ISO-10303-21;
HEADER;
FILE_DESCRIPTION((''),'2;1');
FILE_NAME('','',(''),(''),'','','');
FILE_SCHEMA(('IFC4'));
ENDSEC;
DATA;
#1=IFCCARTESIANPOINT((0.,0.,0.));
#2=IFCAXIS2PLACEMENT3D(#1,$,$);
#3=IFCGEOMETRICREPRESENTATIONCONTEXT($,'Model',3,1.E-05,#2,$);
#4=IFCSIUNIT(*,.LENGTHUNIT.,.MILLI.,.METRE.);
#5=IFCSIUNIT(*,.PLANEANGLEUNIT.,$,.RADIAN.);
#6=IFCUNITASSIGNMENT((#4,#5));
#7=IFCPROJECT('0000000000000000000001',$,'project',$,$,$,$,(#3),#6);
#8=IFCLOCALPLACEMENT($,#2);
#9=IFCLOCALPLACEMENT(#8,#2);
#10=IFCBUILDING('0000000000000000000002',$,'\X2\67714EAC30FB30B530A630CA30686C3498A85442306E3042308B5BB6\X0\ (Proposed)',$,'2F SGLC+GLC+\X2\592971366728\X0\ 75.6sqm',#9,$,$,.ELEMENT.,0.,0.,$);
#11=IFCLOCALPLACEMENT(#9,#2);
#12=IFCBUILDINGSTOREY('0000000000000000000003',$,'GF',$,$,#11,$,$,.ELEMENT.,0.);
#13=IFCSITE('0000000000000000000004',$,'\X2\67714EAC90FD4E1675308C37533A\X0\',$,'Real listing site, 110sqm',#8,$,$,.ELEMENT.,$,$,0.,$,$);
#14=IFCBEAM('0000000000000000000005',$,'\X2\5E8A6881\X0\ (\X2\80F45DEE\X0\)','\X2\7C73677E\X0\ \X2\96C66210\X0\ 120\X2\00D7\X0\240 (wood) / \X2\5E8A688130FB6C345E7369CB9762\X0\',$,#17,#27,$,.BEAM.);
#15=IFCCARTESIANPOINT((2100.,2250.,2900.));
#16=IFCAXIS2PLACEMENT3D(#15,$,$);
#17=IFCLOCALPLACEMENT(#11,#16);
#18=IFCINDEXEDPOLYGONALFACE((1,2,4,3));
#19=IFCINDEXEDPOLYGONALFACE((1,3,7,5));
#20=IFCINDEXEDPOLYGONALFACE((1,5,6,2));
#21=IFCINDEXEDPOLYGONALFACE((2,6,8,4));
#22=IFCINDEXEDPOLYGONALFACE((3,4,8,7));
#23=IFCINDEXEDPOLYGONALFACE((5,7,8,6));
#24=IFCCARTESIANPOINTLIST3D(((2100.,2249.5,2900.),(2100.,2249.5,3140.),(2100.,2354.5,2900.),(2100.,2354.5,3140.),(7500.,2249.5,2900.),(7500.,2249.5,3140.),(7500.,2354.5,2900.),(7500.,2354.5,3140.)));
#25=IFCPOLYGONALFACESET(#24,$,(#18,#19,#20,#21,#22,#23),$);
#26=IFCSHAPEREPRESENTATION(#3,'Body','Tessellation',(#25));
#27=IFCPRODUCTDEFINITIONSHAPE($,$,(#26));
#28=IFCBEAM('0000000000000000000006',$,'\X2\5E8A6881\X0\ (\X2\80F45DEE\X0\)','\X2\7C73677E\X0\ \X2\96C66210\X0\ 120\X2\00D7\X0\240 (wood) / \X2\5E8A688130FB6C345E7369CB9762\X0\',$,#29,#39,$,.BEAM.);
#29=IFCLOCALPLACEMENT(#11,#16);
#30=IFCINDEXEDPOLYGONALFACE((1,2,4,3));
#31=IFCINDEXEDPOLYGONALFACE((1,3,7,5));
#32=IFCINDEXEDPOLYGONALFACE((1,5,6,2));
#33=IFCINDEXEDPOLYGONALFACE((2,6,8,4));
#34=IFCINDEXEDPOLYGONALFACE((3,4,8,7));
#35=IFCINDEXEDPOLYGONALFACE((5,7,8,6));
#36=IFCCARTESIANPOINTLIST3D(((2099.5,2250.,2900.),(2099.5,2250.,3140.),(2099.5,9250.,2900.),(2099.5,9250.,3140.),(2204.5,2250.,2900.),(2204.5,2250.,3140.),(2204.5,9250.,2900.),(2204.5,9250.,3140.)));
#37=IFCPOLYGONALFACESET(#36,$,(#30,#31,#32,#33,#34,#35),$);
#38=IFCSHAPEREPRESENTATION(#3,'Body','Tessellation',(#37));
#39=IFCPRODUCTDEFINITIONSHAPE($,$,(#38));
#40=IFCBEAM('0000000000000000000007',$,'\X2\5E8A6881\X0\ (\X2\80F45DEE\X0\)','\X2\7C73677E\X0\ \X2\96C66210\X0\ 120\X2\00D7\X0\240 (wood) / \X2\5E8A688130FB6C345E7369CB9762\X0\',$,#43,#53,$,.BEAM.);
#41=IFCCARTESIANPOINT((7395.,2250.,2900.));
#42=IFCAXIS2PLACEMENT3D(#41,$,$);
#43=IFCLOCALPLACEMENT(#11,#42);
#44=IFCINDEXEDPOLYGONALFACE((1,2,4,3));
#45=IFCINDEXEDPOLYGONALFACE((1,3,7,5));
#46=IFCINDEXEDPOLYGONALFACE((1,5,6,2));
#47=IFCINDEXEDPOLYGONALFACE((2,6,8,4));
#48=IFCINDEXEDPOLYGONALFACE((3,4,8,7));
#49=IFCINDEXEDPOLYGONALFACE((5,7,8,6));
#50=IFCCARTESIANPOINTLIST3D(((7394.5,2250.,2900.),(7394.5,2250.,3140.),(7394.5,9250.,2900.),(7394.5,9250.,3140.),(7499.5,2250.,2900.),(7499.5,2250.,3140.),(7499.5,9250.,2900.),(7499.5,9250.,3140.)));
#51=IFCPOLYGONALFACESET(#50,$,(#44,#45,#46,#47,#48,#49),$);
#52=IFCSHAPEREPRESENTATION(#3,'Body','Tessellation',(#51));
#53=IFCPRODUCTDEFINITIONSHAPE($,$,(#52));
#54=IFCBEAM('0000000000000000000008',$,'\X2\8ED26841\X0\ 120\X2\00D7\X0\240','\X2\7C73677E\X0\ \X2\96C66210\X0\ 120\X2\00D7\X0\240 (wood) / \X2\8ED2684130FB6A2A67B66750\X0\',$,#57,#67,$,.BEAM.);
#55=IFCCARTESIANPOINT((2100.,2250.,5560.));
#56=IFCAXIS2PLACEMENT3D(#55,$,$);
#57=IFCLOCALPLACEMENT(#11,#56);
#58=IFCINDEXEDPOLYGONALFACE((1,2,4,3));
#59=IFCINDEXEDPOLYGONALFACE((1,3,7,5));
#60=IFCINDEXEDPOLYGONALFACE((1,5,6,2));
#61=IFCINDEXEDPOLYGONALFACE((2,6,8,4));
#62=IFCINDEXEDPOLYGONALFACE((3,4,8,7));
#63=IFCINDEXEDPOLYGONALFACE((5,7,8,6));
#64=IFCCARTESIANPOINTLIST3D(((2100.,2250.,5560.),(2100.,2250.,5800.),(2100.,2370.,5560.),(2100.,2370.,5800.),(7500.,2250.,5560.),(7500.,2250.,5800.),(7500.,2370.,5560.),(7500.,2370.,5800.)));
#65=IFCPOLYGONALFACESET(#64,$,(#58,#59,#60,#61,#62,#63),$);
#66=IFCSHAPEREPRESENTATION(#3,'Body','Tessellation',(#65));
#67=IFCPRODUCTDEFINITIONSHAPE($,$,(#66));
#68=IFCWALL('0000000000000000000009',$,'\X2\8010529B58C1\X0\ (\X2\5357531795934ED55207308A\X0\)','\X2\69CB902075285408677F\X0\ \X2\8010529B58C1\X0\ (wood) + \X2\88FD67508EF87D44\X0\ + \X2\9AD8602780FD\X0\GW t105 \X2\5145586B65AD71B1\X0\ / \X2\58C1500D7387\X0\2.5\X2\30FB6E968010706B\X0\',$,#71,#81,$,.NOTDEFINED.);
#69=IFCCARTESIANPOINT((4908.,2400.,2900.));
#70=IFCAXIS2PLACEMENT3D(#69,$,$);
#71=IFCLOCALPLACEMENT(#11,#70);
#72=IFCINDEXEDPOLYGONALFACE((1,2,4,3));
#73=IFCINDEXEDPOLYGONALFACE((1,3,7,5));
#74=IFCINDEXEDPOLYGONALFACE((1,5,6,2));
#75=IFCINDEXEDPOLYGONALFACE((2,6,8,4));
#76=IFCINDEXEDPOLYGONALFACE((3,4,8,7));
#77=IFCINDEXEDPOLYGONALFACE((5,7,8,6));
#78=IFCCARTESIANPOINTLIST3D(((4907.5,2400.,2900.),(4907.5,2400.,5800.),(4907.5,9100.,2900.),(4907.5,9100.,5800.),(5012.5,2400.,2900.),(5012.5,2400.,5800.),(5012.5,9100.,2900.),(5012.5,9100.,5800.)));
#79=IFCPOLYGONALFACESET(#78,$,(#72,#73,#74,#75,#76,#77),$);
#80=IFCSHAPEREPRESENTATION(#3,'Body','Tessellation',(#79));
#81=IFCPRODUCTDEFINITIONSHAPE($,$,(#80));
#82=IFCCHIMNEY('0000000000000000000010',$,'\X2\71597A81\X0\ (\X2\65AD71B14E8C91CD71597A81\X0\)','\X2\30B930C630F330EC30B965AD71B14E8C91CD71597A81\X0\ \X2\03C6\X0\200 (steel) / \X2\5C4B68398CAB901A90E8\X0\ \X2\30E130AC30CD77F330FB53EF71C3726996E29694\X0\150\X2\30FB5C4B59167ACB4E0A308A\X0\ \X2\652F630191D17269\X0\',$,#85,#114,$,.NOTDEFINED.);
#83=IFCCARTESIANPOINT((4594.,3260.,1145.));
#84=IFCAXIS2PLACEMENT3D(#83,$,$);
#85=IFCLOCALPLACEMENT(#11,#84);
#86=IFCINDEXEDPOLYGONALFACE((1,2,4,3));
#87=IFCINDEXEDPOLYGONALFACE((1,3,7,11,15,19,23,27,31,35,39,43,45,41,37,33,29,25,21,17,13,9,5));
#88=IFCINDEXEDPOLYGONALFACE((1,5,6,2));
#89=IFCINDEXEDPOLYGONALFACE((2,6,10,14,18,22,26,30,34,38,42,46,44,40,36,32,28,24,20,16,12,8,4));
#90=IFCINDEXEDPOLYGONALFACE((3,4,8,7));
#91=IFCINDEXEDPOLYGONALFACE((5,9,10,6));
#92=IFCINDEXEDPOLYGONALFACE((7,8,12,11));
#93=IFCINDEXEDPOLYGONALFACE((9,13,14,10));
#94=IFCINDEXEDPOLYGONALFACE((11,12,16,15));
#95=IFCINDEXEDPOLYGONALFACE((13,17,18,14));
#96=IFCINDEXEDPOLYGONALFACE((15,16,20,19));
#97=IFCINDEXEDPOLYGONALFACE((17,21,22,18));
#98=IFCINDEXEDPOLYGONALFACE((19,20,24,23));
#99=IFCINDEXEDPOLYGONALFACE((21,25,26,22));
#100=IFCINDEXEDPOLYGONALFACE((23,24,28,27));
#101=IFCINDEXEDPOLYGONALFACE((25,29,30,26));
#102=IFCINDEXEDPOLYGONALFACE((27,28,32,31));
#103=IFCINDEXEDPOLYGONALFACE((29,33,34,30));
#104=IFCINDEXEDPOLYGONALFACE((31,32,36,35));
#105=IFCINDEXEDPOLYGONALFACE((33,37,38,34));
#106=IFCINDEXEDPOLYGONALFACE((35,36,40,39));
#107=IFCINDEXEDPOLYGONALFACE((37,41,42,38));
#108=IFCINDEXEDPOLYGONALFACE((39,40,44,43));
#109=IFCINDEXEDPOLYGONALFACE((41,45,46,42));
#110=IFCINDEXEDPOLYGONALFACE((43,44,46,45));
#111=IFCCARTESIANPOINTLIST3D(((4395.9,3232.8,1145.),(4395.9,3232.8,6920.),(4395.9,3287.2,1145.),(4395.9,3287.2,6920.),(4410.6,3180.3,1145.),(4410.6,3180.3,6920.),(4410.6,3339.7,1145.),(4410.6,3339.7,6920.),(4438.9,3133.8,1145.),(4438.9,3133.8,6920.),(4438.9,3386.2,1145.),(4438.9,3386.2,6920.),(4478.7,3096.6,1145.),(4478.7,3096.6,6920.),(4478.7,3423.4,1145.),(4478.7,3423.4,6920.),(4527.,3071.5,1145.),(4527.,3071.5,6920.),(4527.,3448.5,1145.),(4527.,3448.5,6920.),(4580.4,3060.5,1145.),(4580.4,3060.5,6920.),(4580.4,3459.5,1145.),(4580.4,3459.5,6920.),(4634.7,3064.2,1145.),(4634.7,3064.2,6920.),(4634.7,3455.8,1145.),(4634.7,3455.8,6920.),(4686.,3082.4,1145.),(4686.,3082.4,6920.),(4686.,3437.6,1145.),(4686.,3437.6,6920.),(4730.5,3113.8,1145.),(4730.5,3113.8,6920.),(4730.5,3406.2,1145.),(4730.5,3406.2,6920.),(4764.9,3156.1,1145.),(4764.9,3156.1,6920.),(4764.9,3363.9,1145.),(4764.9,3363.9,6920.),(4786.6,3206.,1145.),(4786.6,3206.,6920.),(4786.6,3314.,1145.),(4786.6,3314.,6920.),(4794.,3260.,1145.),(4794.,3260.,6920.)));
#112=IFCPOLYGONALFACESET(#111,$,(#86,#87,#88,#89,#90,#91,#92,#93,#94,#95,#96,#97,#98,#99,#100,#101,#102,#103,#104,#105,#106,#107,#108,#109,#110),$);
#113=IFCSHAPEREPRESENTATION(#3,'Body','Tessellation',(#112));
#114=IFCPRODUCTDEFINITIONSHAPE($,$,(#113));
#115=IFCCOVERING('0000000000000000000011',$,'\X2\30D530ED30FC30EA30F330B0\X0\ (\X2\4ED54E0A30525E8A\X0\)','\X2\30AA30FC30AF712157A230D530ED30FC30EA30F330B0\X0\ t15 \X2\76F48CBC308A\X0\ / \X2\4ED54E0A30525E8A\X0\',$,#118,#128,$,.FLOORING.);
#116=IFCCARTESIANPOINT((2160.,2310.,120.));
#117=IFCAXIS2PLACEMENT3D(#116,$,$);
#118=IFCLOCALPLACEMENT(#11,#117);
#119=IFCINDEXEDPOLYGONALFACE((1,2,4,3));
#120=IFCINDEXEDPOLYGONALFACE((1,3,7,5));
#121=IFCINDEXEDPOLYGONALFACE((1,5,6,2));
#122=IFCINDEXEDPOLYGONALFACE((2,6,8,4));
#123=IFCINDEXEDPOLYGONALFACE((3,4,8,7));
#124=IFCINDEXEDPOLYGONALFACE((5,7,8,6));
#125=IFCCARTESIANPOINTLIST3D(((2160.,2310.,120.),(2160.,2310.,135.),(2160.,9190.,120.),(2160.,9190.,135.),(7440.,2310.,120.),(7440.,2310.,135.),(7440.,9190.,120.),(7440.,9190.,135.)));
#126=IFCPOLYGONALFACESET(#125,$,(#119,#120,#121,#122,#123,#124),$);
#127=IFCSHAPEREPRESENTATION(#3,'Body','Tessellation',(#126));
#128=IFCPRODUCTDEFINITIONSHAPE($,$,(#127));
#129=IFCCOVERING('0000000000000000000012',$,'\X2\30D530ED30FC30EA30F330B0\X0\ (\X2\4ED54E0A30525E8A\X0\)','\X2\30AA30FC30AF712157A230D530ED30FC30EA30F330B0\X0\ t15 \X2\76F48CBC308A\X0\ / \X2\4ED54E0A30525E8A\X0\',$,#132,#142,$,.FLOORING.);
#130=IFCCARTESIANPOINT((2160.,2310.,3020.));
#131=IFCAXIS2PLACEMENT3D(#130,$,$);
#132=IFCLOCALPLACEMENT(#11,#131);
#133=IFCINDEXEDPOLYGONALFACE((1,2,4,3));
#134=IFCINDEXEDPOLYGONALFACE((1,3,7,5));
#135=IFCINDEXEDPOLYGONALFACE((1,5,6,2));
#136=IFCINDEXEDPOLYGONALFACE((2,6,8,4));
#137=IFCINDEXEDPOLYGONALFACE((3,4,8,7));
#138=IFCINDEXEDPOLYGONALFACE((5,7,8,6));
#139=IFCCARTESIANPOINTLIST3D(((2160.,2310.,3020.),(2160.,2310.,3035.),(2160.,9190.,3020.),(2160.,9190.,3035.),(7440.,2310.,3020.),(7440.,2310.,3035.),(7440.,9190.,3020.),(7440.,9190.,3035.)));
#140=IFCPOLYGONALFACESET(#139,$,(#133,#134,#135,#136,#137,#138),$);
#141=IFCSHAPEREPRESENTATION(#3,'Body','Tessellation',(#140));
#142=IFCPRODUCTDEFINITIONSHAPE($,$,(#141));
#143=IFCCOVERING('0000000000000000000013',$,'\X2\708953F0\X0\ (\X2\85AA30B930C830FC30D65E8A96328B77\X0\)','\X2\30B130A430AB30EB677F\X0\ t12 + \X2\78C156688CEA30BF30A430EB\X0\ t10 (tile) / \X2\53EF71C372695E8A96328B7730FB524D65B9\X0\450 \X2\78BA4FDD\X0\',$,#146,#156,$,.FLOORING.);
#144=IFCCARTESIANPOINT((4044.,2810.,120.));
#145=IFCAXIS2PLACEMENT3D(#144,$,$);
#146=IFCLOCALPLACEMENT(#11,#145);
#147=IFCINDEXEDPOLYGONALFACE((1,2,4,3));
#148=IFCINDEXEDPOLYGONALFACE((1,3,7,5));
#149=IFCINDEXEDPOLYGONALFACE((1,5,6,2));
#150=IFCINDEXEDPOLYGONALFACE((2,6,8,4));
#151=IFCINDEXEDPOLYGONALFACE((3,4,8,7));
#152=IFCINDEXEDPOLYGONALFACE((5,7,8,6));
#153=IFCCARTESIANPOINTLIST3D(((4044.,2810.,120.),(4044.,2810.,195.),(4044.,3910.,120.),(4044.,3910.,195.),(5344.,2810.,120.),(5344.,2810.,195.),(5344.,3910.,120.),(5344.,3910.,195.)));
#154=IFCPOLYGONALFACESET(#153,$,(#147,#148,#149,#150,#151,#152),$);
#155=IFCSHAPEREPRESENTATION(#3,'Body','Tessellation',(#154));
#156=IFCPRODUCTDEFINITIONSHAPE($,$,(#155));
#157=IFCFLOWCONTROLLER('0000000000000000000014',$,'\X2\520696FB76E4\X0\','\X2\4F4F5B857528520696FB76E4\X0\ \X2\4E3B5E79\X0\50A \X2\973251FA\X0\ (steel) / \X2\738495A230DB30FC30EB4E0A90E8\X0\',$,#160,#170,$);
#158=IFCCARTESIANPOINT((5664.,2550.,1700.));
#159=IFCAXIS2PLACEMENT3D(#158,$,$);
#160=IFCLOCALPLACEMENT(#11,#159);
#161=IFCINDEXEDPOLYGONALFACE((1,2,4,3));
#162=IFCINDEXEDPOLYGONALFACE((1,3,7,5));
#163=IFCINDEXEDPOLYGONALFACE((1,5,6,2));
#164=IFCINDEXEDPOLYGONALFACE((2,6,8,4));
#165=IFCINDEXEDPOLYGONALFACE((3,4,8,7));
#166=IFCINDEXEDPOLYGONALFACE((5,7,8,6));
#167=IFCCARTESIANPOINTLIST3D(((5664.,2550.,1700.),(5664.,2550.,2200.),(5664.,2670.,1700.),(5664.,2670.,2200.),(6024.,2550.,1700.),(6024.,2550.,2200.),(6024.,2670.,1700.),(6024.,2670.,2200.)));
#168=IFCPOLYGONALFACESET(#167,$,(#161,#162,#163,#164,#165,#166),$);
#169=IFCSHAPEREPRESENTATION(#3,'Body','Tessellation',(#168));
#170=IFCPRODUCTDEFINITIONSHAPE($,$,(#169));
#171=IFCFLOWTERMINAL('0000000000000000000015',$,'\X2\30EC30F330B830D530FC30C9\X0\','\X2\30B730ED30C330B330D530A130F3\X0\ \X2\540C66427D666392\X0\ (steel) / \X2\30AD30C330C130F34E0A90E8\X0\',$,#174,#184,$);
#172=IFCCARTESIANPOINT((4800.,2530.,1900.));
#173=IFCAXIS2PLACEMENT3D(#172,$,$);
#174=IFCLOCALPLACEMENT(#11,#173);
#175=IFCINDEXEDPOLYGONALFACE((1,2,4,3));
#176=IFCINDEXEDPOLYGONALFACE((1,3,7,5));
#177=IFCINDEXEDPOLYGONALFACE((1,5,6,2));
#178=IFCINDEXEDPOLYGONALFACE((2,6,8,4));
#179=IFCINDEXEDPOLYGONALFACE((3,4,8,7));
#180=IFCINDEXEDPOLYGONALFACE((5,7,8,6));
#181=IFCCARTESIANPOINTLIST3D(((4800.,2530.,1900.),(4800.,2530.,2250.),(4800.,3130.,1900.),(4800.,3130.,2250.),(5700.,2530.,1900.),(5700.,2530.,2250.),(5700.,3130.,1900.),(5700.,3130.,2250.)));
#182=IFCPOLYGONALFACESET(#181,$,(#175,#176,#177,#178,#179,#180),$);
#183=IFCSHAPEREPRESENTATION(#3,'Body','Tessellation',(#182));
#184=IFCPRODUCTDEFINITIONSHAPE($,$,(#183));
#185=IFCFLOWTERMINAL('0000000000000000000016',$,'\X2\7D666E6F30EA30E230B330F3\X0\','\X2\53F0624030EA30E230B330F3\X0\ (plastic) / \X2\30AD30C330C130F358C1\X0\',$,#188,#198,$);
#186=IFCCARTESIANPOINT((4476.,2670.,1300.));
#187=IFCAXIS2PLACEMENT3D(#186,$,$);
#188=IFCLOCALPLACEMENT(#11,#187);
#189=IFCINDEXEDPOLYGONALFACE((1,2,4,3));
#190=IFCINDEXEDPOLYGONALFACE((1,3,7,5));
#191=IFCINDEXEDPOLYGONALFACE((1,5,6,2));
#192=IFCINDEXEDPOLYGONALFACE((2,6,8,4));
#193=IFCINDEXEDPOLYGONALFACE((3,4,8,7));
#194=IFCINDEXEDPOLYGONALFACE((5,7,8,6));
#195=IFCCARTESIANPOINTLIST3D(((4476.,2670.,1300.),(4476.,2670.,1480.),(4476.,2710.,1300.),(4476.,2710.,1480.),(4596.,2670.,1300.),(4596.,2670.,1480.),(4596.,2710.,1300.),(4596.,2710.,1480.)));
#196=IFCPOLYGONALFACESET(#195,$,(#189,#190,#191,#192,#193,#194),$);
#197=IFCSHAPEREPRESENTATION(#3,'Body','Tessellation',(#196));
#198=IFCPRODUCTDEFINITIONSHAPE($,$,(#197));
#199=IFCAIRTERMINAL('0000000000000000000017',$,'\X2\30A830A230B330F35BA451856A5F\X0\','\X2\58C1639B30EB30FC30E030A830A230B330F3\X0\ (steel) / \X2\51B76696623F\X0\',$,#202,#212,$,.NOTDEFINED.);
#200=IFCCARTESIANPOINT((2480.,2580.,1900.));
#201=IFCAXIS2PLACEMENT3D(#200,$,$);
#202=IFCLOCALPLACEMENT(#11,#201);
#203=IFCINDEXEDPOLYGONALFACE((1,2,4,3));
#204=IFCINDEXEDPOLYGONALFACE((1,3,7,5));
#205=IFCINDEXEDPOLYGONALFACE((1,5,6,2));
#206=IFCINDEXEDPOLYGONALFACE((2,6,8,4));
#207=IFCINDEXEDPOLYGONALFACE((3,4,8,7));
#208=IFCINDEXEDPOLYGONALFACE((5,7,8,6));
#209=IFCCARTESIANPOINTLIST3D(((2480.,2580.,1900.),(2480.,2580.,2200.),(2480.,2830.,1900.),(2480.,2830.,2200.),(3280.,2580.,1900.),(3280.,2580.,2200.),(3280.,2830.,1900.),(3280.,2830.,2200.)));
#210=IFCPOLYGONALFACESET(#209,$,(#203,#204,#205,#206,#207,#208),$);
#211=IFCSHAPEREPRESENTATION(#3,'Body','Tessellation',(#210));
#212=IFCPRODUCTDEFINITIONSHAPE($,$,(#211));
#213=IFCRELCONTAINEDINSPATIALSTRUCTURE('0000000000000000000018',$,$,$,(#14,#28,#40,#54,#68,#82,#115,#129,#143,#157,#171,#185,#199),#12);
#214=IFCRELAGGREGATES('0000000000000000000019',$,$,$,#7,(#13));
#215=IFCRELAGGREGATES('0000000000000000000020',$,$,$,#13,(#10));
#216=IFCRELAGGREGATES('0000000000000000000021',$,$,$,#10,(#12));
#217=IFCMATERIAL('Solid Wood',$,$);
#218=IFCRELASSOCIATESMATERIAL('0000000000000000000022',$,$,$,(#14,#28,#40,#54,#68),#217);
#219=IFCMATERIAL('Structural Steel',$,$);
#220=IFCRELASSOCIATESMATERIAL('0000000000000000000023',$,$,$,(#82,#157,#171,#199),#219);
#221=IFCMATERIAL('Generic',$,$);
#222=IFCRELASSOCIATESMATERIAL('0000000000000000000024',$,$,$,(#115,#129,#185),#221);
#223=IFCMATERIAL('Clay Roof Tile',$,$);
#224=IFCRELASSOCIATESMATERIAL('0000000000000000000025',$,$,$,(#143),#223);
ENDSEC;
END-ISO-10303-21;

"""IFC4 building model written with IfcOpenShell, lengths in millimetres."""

from ifc_helpers import new_model, si_unit, frame, frame_2d, origin, origin_2d, place, context, project, spatial, rectangle, circle, extrude, material, element, save


model = new_model("IFC4")

# Units and contexts
model_context = context("Model", 3, precision=1e-05, world=origin())
ifc_project = project(units=[si_unit("LENGTHUNIT", "METRE", prefix="MILLI"), si_unit("PLANEANGLEUNIT", "RADIAN")], contexts=[model_context])

# Site, building, storey
site_placement = place(None, origin())
site = spatial("IfcSite", under=ifc_project, at=site_placement, Name="東京都世田谷区", ObjectType="Real listing site, 110sqm", CompositionType="ELEMENT", RefElevation=0.0)
building_placement = place(site_placement, origin())
building = spatial("IfcBuilding", under=site, at=building_placement, Name="東京・サウナと水風呂のある家 (Proposed)", ObjectType="2F SGLC+GLC+天然木 75.6sqm", CompositionType="ELEMENT", ElevationOfRefHeight=0.0, ElevationOfTerrain=0.0)
storey_placement = place(building_placement, origin())
storey = spatial("IfcBuildingStorey", under=building, at=storey_placement, Name="GF", CompositionType="ELEMENT", Elevation=0.0)

# Beams
ifc_material_1 = material(Name="Solid Wood")
beam_1_placement = place(storey_placement, frame((2100.0, 2250.0, 2900.0)))
element("IfcBeam", 1, at=beam_1_placement, inside=storey, material=ifc_material_1, Name="床梁 (胴差)", Description="米松 集成 120×240 (wood) / 床梁・水平構面", PredefinedType="BEAM", context=model_context, shape_type="SweptSolid", body=[
    extrude(rectangle(XDim=5400.0, YDim=105.0, at=frame_2d((2700.0, 52.0))), frame((2100.0, 2250.0, 2900.0)), (0.0, 0.0, 1.0), 240.0),
])
beam_2_placement = place(storey_placement, frame((2100.0, 2250.0, 2900.0)))
element("IfcBeam", 2, at=beam_2_placement, inside=storey, material=ifc_material_1, Name="床梁 (胴差)", Description="米松 集成 120×240 (wood) / 床梁・水平構面", PredefinedType="BEAM", context=model_context, shape_type="SweptSolid", body=[
    extrude(rectangle(XDim=105.0, YDim=7000.0, at=frame_2d((52.0, 3500.0))), frame((2100.0, 2250.0, 2900.0)), (0.0, 0.0, 1.0), 240.0),
])
beam_3_placement = place(storey_placement, frame((7395.0, 2250.0, 2900.0)))
element("IfcBeam", 3, at=beam_3_placement, inside=storey, material=ifc_material_1, Name="床梁 (胴差)", Description="米松 集成 120×240 (wood) / 床梁・水平構面", PredefinedType="BEAM", context=model_context, shape_type="SweptSolid", body=[
    extrude(rectangle(XDim=105.0, YDim=7000.0, at=frame_2d((52.0, 3500.0))), frame((7395.0, 2250.0, 2900.0)), (0.0, 0.0, 1.0), 240.0),
])
beam_4_placement = place(storey_placement, frame((2100.0, 2250.0, 5560.0)))
element("IfcBeam", 4, at=beam_4_placement, inside=storey, material=ifc_material_1, Name="軒桁 120×240", Description="米松 集成 120×240 (wood) / 軒桁・横架材", PredefinedType="BEAM", context=model_context, shape_type="SweptSolid", body=[
    extrude(rectangle(XDim=5400.0, YDim=120.0, at=frame_2d((2700.0, 60.0))), frame((2100.0, 2250.0, 5560.0)), (0.0, 0.0, 1.0), 240.0),
])

# Wall
wall_1_placement = place(storey_placement, frame((4908.0, 2400.0, 2900.0)))
element("IfcWall", 5, at=wall_1_placement, inside=storey, material=ifc_material_1, Name="耐力壁 (南北間仕切り)", Description="構造用合板 耐力壁 (wood) + 製材軸組 + 高性能GW t105 充填断熱 / 壁倍率2.5・準耐火", PredefinedType="NOTDEFINED", context=model_context, shape_type="SweptSolid", body=[
    extrude(rectangle(XDim=105.0, YDim=6700.0, at=frame_2d((52.0, 3350.0))), frame((4908.0, 2400.0, 2900.0)), (0.0, 0.0, 1.0), 2900.0),
])

# Chimney
ifc_material_2 = material(Name="Structural Steel")
chimney_placement = place(storey_placement, frame((4594.0, 3260.0, 1145.0)))
element("IfcChimney", 6, at=chimney_placement, inside=storey, material=ifc_material_2, Name="煙突 (断熱二重煙突)", Description="ステンレス断熱二重煙突 φ200 (steel) / 屋根貫通部 メガネ石・可燃物離隔150・屋外立上り 支持金物", PredefinedType="NOTDEFINED", context=model_context, shape_type="SweptSolid", body=[
    extrude(circle(Radius=200.0, at=origin_2d()), frame((4594.0, 3260.0, 1145.0)), (0.0, 0.0, 1.0), 5775.0),
])

# Coverings
ifc_material_3 = material(Name="Generic")
covering_1_placement = place(storey_placement, frame((2160.0, 2310.0, 120.0)))
element("IfcCovering", 7, at=covering_1_placement, inside=storey, material=ifc_material_3, Name="フローリング (仕上げ床)", Description="オーク無垢フローリング t15 直貼り / 仕上げ床", PredefinedType="FLOORING", context=model_context, shape_type="SweptSolid", body=[
    extrude(rectangle(XDim=5280.0, YDim=6880.0, at=frame_2d((2640.0, 3440.0))), frame((2160.0, 2310.0, 120.0)), (0.0, 0.0, 1.0), 15.0),
])
covering_2_placement = place(storey_placement, frame((2160.0, 2310.0, 3020.0)))
element("IfcCovering", 8, at=covering_2_placement, inside=storey, material=ifc_material_3, Name="フローリング (仕上げ床)", Description="オーク無垢フローリング t15 直貼り / 仕上げ床", PredefinedType="FLOORING", context=model_context, shape_type="SweptSolid", body=[
    extrude(rectangle(XDim=5280.0, YDim=6880.0, at=frame_2d((2640.0, 3440.0))), frame((2160.0, 2310.0, 3020.0)), (0.0, 0.0, 1.0), 15.0),
])
ifc_material_4 = material(Name="Clay Roof Tile")
covering_3_placement = place(storey_placement, frame((4044.0, 2810.0, 120.0)))
element("IfcCovering", 9, at=covering_3_placement, inside=storey, material=ifc_material_4, Name="炉台 (薪ストーブ床防護)", Description="ケイカル板 t12 + 磁器質タイル t10 (tile) / 可燃物床防護・前方450 確保", PredefinedType="FLOORING", context=model_context, shape_type="SweptSolid", body=[
    extrude(rectangle(XDim=1300.0, YDim=1100.0, at=frame_2d((650.0, 550.0))), frame((4044.0, 2810.0, 120.0)), (0.0, 0.0, 1.0), 75.0),
])

# Flow controller
flow_controller_placement = place(storey_placement, frame((5664.0, 2550.0, 1700.0)))
element("IfcFlowController", 10, at=flow_controller_placement, inside=storey, material=ifc_material_2, Name="分電盤", Description="住宅用分電盤 主幹50A 露出 (steel) / 玄関ホール上部", context=model_context, shape_type="SweptSolid", body=[
    extrude(rectangle(XDim=360.0, YDim=120.0, at=frame_2d((180.0, 60.0))), frame((5664.0, 2550.0, 1700.0)), (0.0, 0.0, 1.0), 500.0),
])

# Flow terminals
flow_terminal_1_placement = place(storey_placement, frame((4800.0, 2530.0, 1900.0)))
element("IfcFlowTerminal", 11, at=flow_terminal_1_placement, inside=storey, material=ifc_material_2, Name="レンジフード", Description="シロッコファン 同時給排 (steel) / キッチン上部", context=model_context, shape_type="SweptSolid", body=[
    extrude(rectangle(XDim=900.0, YDim=600.0, at=frame_2d((450.0, 300.0))), frame((4800.0, 2530.0, 1900.0)), (0.0, 0.0, 1.0), 350.0),
])
flow_terminal_2_placement = place(storey_placement, frame((4476.0, 2670.0, 1300.0)))
element("IfcFlowTerminal", 12, at=flow_terminal_2_placement, inside=storey, material=ifc_material_3, Name="給湯リモコン", Description="台所リモコン (plastic) / キッチン壁", context=model_context, shape_type="SweptSolid", body=[
    extrude(rectangle(XDim=120.0, YDim=40.0, at=frame_2d((60.0, 20.0))), frame((4476.0, 2670.0, 1300.0)), (0.0, 0.0, 1.0), 180.0),
])

# Air terminal
air_terminal_1_placement = place(storey_placement, frame((2480.0, 2580.0, 1900.0)))
element("IfcAirTerminal", 13, at=air_terminal_1_placement, inside=storey, material=ifc_material_2, Name="エアコン室内機", Description="壁掛ルームエアコン (steel) / 冷暖房", PredefinedType="NOTDEFINED", context=model_context, shape_type="SweptSolid", body=[
    extrude(rectangle(XDim=800.0, YDim=250.0, at=frame_2d((400.0, 125.0))), frame((2480.0, 2580.0, 1900.0)), (0.0, 0.0, 1.0), 300.0),
])

save(model, "model.ifc")
